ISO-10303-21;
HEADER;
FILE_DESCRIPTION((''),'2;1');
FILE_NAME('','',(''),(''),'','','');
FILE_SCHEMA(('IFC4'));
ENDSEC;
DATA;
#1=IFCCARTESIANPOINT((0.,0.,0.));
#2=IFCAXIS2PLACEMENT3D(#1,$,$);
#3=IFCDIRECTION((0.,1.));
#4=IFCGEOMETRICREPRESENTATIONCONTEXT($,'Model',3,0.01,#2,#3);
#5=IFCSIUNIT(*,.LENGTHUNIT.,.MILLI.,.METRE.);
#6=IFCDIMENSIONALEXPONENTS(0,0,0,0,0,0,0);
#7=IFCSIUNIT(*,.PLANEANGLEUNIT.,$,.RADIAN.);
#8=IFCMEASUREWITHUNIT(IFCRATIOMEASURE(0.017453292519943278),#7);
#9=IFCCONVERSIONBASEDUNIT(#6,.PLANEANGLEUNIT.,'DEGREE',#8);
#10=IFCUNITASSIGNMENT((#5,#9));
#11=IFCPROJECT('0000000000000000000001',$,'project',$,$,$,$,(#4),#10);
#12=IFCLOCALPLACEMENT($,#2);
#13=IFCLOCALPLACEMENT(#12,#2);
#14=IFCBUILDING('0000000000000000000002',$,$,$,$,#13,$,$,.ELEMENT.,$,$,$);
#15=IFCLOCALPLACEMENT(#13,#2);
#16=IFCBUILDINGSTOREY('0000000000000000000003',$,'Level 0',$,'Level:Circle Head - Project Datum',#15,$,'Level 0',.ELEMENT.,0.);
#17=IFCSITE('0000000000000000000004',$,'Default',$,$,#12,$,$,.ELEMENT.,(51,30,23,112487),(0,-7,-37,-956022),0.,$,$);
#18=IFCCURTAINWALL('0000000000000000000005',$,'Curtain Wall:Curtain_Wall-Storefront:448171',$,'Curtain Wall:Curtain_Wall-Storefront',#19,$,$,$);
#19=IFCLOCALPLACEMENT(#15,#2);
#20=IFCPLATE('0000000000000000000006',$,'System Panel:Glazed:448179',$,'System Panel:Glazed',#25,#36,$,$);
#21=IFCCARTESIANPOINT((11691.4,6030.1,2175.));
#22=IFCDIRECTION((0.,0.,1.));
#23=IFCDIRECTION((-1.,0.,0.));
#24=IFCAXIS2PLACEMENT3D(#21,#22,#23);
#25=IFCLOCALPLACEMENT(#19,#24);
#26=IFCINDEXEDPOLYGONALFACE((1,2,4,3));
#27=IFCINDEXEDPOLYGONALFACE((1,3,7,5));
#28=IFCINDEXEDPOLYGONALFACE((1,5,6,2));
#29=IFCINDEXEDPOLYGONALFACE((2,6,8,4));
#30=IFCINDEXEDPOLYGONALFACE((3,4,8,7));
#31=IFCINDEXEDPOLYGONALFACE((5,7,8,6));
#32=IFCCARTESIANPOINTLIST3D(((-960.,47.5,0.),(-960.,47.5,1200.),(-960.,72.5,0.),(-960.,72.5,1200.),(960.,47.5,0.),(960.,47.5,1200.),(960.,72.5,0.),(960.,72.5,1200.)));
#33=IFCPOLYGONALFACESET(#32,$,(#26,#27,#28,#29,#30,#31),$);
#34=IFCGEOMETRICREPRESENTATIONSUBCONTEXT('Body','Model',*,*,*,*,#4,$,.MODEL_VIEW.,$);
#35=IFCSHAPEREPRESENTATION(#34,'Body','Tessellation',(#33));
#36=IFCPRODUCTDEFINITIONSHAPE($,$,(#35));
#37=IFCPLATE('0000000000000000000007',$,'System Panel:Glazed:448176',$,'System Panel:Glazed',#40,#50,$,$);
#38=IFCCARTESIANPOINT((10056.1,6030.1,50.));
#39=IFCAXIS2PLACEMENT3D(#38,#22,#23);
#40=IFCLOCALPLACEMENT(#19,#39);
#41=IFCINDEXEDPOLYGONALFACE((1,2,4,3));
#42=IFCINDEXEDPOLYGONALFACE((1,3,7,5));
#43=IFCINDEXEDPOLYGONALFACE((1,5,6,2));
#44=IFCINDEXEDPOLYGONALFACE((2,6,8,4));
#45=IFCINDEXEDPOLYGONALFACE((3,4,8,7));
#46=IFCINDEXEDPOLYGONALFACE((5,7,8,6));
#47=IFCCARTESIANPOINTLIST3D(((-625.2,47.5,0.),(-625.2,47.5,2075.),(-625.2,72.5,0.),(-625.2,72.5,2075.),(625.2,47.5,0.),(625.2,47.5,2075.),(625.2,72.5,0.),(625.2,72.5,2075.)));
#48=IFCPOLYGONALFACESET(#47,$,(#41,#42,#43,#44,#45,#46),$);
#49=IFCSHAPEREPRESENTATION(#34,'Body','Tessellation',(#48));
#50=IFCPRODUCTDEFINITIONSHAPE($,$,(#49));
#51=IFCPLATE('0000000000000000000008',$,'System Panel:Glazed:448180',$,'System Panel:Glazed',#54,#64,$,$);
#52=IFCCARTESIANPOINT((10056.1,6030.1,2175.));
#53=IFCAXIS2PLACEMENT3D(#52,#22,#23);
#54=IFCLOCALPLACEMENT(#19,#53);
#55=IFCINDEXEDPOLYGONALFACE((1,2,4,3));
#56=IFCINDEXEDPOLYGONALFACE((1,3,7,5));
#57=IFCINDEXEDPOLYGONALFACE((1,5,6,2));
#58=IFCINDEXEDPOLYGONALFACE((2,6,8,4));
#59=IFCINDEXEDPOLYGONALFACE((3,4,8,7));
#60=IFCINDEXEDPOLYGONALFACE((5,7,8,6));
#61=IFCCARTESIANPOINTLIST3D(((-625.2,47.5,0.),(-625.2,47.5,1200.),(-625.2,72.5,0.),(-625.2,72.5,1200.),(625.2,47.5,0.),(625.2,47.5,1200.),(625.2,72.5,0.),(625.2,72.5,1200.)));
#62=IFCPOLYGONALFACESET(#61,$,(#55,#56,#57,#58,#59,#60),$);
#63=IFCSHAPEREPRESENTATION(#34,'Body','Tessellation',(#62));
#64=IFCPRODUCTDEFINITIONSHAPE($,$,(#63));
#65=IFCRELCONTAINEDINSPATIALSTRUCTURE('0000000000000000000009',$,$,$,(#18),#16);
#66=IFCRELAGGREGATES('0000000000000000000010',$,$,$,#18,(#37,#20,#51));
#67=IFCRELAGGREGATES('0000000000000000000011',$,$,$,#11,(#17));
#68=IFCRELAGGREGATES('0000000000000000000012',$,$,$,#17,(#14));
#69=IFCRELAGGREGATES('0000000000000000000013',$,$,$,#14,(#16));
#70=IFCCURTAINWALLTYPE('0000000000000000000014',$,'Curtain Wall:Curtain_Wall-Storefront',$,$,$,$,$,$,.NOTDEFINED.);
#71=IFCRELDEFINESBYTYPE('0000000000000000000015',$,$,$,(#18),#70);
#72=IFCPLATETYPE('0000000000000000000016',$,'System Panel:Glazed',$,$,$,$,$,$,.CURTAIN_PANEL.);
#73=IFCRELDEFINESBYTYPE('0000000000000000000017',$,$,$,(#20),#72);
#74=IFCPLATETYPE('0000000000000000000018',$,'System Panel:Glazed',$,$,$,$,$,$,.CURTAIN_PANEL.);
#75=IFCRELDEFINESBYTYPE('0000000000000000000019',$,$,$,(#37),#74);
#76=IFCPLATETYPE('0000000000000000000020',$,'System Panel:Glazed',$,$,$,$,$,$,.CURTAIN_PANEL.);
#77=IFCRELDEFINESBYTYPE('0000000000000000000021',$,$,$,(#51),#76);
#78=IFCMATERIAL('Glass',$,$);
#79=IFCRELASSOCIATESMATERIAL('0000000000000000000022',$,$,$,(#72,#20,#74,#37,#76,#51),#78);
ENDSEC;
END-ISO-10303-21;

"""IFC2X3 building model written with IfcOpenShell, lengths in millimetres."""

from ifc_helpers import new_model, entity, si_unit, converted_unit, direction, frame, origin, origin_2d_with_axis, place, context, subcontext, project, spatial, rectangle, extrude, source, transform, mapped, material, type_object, type_shapes, element, aggregate, save


model = new_model("IFC2X3")

# Units and contexts
model_context = context("Model", 3, precision=0.01, world=origin(), true_north=direction((0.0, 1.0)))
body_context = subcontext(model_context, "Body", "Model", "MODEL_VIEW")
ifc_project = project(units=[si_unit("LENGTHUNIT", "METRE", prefix="MILLI"), converted_unit("PLANEANGLEUNIT", "DEGREE", entity("IfcRatioMeasure", 0.017453292519943278), si_unit("PLANEANGLEUNIT", "RADIAN"), dimensions=[0, 0, 0, 0, 0, 0, 0])], contexts=[model_context])

# Site, building, storey
site_placement = place(None, origin())
site = spatial("IfcSite", under=ifc_project, at=site_placement, Name="Default", CompositionType="ELEMENT", RefLatitude=(51, 30, 23, 112487), RefLongitude=(0, -7, -37, -956022), RefElevation=0.0)
building_placement = place(site_placement, origin())
building = spatial("IfcBuilding", under=site, at=building_placement, CompositionType="ELEMENT")
storey_placement = place(building_placement, origin())
storey = spatial("IfcBuildingStorey", under=building, at=storey_placement, Name="Level 0", ObjectType="Level:Circle Head - Project Datum", LongName="Level 0", CompositionType="ELEMENT", Elevation=0.0)

# Curtain wall
curtain_wall_type = type_object("IfcCurtainWallType", Name="Curtain Wall:Curtain_Wall-Storefront", PredefinedType="NOTDEFINED")
curtain_wall_1_placement = place(storey_placement, origin())
curtain_wall_1 = element("IfcCurtainWall", 1, at=curtain_wall_1_placement, inside=storey, type_object=curtain_wall_type, Name="Curtain Wall:Curtain_Wall-Storefront:448171", ObjectType="Curtain Wall:Curtain_Wall-Storefront")

# Plates
ifc_material_1 = material(Name="Glass")
plate_type_1 = type_object("IfcPlateType", Name="System Panel:Glazed", PredefinedType="CURTAIN_PANEL", material=ifc_material_1)
shared_shape_1 = source(origin(), body_context, "Body", "SweptSolid", [
    extrude(rectangle(XDim=25.0, YDim=1920.0, at=origin_2d_with_axis()), frame((0.0, 60.0, 0.0), z_axis=(0.0, 0.0, 1.0), x_axis=(0.0, 1.0, 0.0)), (0.0, 0.0, 1.0), 1200.0),
])
type_shapes(plate_type_1, [shared_shape_1])
plate_1_placement = place(curtain_wall_1_placement, frame((11691.4, 6030.1, 2175.0), z_axis=(0.0, 0.0, 1.0), x_axis=(-1.0, 0.0, 0.0)))
plate_1 = element("IfcPlate", 2, at=plate_1_placement, type_object=plate_type_1, material=ifc_material_1, Name="System Panel:Glazed:448179", ObjectType="System Panel:Glazed", context=body_context, shape_type="MappedRepresentation", body=[
    mapped(shared_shape_1, transform((0.0, 0.0, 0.0), scale=1.0)),
])
plate_type_2 = type_object("IfcPlateType", Name="System Panel:Glazed", PredefinedType="CURTAIN_PANEL", material=ifc_material_1)
shared_shape_2 = source(origin(), body_context, "Body", "SweptSolid", [
    extrude(rectangle(XDim=25.0, YDim=1250.5, at=origin_2d_with_axis()), frame((0.0, 60.0, 0.0), z_axis=(0.0, 0.0, 1.0), x_axis=(0.0, 1.0, 0.0)), (0.0, 0.0, 1.0), 2075.0),
])
type_shapes(plate_type_2, [shared_shape_2])
plate_2_placement = place(curtain_wall_1_placement, frame((10056.1, 6030.1, 50.0), z_axis=(0.0, 0.0, 1.0), x_axis=(-1.0, 0.0, 0.0)))
plate_2 = element("IfcPlate", 3, at=plate_2_placement, type_object=plate_type_2, material=ifc_material_1, Name="System Panel:Glazed:448176", ObjectType="System Panel:Glazed", context=body_context, shape_type="MappedRepresentation", body=[
    mapped(shared_shape_2, transform((0.0, 0.0, 0.0), scale=1.0)),
])
plate_type_3 = type_object("IfcPlateType", Name="System Panel:Glazed", PredefinedType="CURTAIN_PANEL", material=ifc_material_1)
shared_shape_3 = source(origin(), body_context, "Body", "SweptSolid", [
    extrude(rectangle(XDim=25.0, YDim=1250.5, at=origin_2d_with_axis()), frame((0.0, 60.0, 0.0), z_axis=(0.0, 0.0, 1.0), x_axis=(0.0, 1.0, 0.0)), (0.0, 0.0, 1.0), 1200.0),
])
type_shapes(plate_type_3, [shared_shape_3])
plate_3_placement = place(curtain_wall_1_placement, frame((10056.1, 6030.1, 2175.0), z_axis=(0.0, 0.0, 1.0), x_axis=(-1.0, 0.0, 0.0)))
plate_3 = element("IfcPlate", 4, at=plate_3_placement, type_object=plate_type_3, material=ifc_material_1, Name="System Panel:Glazed:448180", ObjectType="System Panel:Glazed", context=body_context, shape_type="MappedRepresentation", body=[
    mapped(shared_shape_3, transform((0.0, 0.0, 0.0), scale=1.0)),
])
aggregate(curtain_wall_1, [plate_2, plate_1, plate_3])

save(model, "model.ifc")
